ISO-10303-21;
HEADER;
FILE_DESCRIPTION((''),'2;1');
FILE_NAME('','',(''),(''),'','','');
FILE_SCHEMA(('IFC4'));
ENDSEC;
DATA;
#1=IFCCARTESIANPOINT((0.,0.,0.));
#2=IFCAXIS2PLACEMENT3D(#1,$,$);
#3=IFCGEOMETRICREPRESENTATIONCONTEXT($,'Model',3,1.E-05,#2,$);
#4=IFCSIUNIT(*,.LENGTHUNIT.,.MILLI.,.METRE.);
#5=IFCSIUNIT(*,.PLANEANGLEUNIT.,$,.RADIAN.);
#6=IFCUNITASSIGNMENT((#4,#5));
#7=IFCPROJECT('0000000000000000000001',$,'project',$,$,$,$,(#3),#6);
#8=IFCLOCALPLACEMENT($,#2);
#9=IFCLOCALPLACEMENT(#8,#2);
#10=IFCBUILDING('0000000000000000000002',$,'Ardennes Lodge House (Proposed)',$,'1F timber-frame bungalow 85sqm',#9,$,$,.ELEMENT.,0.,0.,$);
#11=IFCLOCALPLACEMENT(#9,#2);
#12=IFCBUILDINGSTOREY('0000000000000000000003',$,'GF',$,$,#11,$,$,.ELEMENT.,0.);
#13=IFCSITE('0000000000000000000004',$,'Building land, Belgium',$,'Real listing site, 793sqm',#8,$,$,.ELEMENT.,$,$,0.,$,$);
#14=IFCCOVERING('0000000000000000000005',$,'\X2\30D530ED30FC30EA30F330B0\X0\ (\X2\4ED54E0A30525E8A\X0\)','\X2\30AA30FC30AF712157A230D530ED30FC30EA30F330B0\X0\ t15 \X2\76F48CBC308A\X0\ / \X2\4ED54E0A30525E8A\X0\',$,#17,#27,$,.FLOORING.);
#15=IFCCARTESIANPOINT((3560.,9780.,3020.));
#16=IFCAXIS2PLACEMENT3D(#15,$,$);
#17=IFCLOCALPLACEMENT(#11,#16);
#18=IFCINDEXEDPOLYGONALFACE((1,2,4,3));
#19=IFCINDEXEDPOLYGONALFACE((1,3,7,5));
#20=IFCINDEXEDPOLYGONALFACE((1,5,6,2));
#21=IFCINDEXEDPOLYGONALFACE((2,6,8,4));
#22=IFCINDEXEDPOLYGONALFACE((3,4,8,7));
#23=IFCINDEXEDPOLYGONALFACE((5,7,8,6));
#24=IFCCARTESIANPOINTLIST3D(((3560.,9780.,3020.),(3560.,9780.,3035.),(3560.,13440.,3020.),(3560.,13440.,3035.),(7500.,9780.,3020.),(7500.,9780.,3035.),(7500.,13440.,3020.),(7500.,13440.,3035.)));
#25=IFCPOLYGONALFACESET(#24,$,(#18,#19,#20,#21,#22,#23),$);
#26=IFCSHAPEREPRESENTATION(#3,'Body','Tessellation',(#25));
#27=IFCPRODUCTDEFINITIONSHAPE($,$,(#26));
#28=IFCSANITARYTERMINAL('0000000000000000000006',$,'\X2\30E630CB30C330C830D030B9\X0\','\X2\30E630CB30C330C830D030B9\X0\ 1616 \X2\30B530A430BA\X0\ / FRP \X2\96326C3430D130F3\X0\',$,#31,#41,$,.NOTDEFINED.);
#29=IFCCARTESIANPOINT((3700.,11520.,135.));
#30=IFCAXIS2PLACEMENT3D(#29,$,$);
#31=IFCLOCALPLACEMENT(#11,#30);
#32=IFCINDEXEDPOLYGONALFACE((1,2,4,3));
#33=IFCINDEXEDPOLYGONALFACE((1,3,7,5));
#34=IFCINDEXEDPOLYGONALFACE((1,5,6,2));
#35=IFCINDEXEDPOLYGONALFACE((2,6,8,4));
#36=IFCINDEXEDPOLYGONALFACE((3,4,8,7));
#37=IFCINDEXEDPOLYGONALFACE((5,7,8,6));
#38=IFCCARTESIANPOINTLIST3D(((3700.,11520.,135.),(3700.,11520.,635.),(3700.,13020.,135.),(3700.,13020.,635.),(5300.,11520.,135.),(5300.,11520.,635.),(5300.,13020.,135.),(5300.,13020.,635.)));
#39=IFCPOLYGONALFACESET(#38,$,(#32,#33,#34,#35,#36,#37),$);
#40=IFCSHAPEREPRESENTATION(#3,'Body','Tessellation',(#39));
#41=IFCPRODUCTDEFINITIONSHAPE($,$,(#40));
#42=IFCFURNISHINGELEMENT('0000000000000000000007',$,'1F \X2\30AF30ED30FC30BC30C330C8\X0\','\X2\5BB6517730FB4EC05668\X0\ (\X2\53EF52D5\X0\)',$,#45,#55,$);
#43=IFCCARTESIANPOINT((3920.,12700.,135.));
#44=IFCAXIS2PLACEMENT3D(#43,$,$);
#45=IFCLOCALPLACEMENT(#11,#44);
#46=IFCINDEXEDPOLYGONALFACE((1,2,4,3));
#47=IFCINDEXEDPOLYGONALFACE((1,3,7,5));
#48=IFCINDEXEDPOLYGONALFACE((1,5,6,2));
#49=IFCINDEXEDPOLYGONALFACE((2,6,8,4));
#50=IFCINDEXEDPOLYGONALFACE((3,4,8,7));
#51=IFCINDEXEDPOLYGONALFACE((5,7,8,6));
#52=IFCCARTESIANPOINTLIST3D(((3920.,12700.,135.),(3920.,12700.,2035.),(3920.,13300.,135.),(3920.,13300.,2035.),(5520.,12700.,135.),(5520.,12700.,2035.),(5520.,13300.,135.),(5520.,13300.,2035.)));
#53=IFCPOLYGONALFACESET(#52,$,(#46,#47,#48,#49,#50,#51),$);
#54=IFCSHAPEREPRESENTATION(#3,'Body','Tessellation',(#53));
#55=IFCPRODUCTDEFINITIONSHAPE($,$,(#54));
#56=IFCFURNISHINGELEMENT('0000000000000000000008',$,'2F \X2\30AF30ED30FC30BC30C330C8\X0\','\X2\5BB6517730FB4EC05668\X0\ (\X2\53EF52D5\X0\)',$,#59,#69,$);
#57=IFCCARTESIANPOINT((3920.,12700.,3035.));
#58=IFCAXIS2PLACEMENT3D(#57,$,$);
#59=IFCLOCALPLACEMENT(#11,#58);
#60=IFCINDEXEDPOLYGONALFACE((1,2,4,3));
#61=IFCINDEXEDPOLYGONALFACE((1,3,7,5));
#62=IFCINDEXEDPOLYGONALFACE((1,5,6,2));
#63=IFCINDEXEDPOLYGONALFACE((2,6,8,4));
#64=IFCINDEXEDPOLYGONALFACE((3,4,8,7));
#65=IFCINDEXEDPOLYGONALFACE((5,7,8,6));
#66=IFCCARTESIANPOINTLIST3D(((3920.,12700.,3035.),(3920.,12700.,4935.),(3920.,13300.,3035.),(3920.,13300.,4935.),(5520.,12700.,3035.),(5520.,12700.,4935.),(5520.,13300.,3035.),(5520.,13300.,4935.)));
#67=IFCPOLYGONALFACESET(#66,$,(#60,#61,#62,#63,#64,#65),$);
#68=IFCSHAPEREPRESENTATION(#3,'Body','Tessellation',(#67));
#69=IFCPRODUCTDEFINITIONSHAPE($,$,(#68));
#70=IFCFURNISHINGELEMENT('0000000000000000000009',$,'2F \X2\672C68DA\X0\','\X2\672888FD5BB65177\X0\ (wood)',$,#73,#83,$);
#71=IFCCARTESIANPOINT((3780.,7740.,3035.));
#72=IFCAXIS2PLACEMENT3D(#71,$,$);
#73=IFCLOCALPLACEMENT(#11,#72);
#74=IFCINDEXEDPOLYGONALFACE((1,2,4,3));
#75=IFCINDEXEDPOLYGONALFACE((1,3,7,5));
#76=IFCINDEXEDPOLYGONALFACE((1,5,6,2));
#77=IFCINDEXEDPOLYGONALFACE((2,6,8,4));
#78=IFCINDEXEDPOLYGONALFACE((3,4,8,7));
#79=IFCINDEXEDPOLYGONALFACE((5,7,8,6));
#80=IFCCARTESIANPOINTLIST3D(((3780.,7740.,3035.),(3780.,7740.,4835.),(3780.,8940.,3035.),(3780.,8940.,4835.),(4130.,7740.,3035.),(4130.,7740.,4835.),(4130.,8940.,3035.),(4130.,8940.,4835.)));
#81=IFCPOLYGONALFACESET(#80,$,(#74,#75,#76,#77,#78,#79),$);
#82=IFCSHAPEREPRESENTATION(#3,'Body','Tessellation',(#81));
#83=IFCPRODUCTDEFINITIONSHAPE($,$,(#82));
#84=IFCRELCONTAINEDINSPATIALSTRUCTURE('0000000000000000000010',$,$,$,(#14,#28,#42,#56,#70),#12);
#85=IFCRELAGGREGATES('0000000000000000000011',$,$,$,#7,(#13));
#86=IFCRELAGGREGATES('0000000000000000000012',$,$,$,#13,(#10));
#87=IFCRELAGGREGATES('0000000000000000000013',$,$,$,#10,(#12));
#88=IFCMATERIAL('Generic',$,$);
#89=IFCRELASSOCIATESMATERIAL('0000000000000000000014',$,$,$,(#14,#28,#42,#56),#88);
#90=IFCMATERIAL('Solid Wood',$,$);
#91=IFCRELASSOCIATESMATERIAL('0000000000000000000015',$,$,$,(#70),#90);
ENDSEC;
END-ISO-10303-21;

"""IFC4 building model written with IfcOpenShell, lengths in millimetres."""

from ifc_helpers import new_model, si_unit, frame, frame_2d, origin, place, context, project, spatial, rectangle, extrude, material, element, save


model = new_model("IFC4")

# Units and contexts
model_context = context("Model", 3, precision=1e-05, world=origin())
ifc_project = project(units=[si_unit("LENGTHUNIT", "METRE", prefix="MILLI"), si_unit("PLANEANGLEUNIT", "RADIAN")], contexts=[model_context])

# Site, building, storey
site_placement = place(None, origin())
site = spatial("IfcSite", under=ifc_project, at=site_placement, Name="Building land, Belgium", ObjectType="Real listing site, 793sqm", CompositionType="ELEMENT", RefElevation=0.0)
building_placement = place(site_placement, origin())
building = spatial("IfcBuilding", under=site, at=building_placement, Name="Ardennes Lodge House (Proposed)", ObjectType="1F timber-frame bungalow 85sqm", CompositionType="ELEMENT", ElevationOfRefHeight=0.0, ElevationOfTerrain=0.0)
storey_placement = place(building_placement, origin())
storey = spatial("IfcBuildingStorey", under=building, at=storey_placement, Name="GF", CompositionType="ELEMENT", Elevation=0.0)

# Shared definitions
ifc_material_1 = material(Name="Solid Wood")

# Covering
ifc_material_2 = material(Name="Generic")
covering_1_placement = place(storey_placement, frame((3560.0, 9780.0, 3020.0)))
element("IfcCovering", 1, at=covering_1_placement, inside=storey, material=ifc_material_2, Name="フローリング (仕上げ床)", Description="オーク無垢フローリング t15 直貼り / 仕上げ床", PredefinedType="FLOORING", context=model_context, shape_type="SweptSolid", body=[
    extrude(rectangle(XDim=3940.0, YDim=3660.0, at=frame_2d((1970.0, 1830.0))), frame((3560.0, 9780.0, 3020.0)), (0.0, 0.0, 1.0), 15.0),
])

# Sanitary terminal
sanitary_terminal_placement = place(storey_placement, frame((3700.0, 11520.0, 135.0)))
element("IfcSanitaryTerminal", 2, at=sanitary_terminal_placement, inside=storey, material=ifc_material_2, Name="ユニットバス", Description="ユニットバス 1616 サイズ / FRP 防水パン", PredefinedType="NOTDEFINED", context=model_context, shape_type="SweptSolid", body=[
    extrude(rectangle(XDim=1600.0, YDim=1500.0, at=frame_2d((800.0, 750.0))), frame((3700.0, 11520.0, 135.0)), (0.0, 0.0, 1.0), 500.0),
])

# Furnishing elements
furnishing_1_placement = place(storey_placement, frame((3920.0, 12700.0, 135.0)))
element("IfcFurnishingElement", 3, at=furnishing_1_placement, inside=storey, material=ifc_material_2, Name="1F クローゼット", Description="家具・什器 (可動)", context=model_context, shape_type="SweptSolid", body=[
    extrude(rectangle(XDim=1600.0, YDim=600.0, at=frame_2d((800.0, 300.0))), frame((3920.0, 12700.0, 135.0)), (0.0, 0.0, 1.0), 1900.0),
])
furnishing_2_placement = place(storey_placement, frame((3920.0, 12700.0, 3035.0)))
element("IfcFurnishingElement", 4, at=furnishing_2_placement, inside=storey, material=ifc_material_2, Name="2F クローゼット", Description="家具・什器 (可動)", context=model_context, shape_type="SweptSolid", body=[
    extrude(rectangle(XDim=1600.0, YDim=600.0, at=frame_2d((800.0, 300.0))), frame((3920.0, 12700.0, 3035.0)), (0.0, 0.0, 1.0), 1900.0),
])
furnishing_3_placement = place(storey_placement, frame((3780.0, 7740.0, 3035.0)))
element("IfcFurnishingElement", 5, at=furnishing_3_placement, inside=storey, material=ifc_material_1, Name="2F 本棚", Description="木製家具 (wood)", context=model_context, shape_type="SweptSolid", body=[
    extrude(rectangle(XDim=350.0, YDim=1200.0, at=frame_2d((175.0, 600.0))), frame((3780.0, 7740.0, 3035.0)), (0.0, 0.0, 1.0), 1800.0),
])

save(model, "model.ifc")
